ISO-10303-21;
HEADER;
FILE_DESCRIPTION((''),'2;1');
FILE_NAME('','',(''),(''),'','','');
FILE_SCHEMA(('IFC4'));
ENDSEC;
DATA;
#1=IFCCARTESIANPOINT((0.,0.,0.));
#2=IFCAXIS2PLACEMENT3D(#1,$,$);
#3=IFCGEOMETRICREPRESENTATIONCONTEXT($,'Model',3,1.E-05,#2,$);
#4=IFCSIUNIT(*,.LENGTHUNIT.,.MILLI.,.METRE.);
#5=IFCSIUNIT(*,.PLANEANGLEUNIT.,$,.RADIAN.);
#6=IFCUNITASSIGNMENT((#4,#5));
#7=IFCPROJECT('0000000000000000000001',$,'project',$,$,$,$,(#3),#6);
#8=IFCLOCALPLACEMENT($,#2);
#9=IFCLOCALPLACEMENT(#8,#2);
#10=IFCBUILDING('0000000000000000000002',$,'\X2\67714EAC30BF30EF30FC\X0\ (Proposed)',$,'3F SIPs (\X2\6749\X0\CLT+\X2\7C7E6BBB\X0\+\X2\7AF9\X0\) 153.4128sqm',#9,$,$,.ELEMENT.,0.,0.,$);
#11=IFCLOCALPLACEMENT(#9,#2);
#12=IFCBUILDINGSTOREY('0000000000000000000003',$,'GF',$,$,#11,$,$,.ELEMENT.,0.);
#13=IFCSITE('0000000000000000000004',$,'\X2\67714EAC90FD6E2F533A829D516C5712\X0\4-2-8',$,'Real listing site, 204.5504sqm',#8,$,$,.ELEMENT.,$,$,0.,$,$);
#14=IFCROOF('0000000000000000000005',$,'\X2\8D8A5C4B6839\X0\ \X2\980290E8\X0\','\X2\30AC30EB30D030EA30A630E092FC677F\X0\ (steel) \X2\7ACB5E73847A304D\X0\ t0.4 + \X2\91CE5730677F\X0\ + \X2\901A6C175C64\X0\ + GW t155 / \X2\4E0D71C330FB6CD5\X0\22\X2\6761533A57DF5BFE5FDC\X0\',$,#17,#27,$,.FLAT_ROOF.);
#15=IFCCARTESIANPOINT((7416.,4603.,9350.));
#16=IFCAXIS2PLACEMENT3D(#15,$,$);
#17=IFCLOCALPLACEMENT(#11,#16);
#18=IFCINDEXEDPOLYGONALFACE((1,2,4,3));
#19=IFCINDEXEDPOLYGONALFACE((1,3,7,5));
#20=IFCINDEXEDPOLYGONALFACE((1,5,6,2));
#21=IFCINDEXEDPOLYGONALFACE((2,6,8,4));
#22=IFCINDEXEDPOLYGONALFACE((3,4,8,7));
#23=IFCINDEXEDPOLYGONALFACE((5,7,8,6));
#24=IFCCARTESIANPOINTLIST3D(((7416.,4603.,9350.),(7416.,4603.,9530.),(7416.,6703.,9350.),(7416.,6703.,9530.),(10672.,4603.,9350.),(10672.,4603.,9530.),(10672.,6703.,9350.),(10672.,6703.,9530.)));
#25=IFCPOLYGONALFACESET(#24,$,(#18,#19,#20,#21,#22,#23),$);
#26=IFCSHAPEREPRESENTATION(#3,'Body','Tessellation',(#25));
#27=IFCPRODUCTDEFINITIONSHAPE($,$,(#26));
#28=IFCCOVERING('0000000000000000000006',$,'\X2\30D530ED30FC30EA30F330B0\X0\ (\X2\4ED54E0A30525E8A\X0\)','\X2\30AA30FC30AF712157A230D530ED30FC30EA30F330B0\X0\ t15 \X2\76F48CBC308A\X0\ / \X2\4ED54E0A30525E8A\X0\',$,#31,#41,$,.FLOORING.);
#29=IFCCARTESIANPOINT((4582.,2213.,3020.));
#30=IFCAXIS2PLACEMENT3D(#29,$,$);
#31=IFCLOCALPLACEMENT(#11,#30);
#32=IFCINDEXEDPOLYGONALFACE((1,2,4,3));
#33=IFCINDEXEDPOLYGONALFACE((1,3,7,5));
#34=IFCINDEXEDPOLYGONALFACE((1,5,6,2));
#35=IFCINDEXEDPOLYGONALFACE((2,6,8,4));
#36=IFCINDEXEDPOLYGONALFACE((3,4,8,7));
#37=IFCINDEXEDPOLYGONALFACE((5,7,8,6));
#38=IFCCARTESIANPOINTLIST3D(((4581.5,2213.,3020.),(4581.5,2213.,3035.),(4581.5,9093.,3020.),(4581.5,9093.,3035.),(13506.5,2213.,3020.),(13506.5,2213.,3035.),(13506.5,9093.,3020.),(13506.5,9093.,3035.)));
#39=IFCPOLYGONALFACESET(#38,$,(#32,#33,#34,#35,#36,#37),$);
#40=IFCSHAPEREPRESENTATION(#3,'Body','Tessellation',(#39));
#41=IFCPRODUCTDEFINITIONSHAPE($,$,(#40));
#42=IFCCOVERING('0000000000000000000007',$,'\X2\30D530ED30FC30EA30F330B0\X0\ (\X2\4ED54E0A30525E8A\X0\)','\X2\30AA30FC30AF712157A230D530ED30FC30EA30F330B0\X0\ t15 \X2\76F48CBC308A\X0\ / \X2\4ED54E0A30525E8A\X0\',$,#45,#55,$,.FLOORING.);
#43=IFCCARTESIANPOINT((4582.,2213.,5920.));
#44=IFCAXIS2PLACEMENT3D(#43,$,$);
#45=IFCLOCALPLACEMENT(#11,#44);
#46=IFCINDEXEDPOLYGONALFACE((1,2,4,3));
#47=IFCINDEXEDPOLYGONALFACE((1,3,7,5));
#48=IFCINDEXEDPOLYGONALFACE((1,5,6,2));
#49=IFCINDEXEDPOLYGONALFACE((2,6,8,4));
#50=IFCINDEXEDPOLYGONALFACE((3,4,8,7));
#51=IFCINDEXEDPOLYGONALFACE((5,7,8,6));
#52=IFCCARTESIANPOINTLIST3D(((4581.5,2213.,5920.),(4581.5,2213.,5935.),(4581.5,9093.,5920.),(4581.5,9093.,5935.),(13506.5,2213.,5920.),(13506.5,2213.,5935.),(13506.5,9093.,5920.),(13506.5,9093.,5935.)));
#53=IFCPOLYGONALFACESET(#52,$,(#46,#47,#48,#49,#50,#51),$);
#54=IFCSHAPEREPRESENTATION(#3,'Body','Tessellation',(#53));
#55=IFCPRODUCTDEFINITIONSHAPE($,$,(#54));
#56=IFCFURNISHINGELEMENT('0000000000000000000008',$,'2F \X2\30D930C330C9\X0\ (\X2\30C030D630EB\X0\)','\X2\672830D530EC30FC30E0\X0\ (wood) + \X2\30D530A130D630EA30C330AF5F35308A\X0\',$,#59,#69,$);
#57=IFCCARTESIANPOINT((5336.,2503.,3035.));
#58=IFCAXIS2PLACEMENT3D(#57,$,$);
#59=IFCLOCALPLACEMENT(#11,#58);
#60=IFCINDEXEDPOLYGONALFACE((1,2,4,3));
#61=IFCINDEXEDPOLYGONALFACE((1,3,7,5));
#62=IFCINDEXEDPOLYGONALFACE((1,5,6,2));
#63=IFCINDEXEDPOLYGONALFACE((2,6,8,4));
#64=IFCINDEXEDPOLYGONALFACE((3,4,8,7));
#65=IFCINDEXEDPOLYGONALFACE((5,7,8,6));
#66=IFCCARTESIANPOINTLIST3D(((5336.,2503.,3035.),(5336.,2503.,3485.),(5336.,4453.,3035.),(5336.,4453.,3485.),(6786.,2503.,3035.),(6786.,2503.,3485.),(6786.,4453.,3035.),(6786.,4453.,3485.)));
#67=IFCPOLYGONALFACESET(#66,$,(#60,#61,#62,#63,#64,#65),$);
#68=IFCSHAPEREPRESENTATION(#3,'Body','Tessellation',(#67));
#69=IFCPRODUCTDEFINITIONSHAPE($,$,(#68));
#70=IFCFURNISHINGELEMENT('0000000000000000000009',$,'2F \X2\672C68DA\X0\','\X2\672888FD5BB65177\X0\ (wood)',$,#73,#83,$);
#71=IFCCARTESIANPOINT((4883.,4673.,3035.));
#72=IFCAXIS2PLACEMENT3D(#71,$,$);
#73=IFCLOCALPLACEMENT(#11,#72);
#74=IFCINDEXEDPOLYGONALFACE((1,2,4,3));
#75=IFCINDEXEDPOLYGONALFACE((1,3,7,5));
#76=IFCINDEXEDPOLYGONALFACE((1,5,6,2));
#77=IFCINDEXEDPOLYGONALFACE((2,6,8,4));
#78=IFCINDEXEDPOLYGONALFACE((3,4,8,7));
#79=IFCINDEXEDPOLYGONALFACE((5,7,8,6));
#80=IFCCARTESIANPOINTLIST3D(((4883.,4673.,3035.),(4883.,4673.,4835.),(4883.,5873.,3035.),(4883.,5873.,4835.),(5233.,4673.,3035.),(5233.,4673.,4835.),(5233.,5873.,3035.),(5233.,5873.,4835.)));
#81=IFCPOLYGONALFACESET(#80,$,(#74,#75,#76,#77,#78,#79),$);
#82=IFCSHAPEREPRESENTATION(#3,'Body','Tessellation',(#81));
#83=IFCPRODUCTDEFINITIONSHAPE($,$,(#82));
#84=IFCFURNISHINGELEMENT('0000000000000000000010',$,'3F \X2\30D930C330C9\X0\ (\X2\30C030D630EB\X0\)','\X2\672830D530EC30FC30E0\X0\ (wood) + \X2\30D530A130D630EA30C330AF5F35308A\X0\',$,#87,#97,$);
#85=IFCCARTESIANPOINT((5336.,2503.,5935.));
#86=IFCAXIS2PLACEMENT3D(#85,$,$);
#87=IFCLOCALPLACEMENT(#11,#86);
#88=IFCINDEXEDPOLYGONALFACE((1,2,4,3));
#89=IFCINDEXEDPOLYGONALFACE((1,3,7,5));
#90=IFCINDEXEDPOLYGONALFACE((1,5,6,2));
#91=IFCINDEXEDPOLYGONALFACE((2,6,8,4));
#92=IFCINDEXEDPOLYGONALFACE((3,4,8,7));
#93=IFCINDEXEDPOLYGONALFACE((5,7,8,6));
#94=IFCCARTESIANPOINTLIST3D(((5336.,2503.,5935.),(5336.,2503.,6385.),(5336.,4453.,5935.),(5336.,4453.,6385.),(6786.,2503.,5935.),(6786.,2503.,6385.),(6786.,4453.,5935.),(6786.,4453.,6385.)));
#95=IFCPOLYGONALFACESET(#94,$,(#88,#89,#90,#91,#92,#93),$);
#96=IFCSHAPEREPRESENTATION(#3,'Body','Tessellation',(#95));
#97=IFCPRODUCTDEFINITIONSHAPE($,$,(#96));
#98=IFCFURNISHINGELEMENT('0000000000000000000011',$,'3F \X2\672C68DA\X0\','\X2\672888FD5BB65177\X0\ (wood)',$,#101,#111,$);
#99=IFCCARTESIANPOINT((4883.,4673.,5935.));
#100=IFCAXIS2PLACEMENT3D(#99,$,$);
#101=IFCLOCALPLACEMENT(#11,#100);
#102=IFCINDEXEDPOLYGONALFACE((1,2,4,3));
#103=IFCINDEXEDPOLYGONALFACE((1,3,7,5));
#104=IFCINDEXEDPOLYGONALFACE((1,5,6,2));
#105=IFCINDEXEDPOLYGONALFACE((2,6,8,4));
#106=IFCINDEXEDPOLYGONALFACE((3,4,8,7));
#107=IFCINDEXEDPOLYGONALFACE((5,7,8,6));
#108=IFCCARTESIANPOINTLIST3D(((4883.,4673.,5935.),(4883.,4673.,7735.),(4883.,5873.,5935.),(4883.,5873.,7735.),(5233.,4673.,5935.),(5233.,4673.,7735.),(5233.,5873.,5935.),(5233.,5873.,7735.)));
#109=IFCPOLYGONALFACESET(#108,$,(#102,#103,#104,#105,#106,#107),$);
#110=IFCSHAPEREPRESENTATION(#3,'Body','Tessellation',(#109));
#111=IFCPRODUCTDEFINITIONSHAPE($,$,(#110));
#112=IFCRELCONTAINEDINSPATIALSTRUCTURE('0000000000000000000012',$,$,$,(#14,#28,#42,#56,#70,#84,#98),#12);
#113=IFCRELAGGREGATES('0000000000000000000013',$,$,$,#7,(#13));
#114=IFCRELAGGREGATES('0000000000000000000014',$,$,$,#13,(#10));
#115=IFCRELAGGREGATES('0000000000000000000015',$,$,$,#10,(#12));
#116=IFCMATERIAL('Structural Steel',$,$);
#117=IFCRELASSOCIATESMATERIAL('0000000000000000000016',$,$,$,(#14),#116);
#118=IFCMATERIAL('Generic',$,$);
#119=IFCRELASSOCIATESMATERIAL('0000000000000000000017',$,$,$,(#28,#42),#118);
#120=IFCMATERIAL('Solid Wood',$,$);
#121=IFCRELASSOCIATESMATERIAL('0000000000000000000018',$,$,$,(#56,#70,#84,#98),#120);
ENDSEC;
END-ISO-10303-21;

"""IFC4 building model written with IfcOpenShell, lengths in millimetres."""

from ifc_helpers import new_model, si_unit, frame, frame_2d, origin, place, context, project, spatial, rectangle, extrude, material, element, save


model = new_model("IFC4")

# Units and contexts
model_context = context("Model", 3, precision=1e-05, world=origin())
ifc_project = project(units=[si_unit("LENGTHUNIT", "METRE", prefix="MILLI"), si_unit("PLANEANGLEUNIT", "RADIAN")], contexts=[model_context])

# Site, building, storey
site_placement = place(None, origin())
site = spatial("IfcSite", under=ifc_project, at=site_placement, Name="東京都港区芝公園4-2-8", ObjectType="Real listing site, 204.5504sqm", CompositionType="ELEMENT", RefElevation=0.0)
building_placement = place(site_placement, origin())
building = spatial("IfcBuilding", under=site, at=building_placement, Name="東京タワー (Proposed)", ObjectType="3F SIPs (杉CLT+籾殻+竹) 153.4128sqm", CompositionType="ELEMENT", ElevationOfRefHeight=0.0, ElevationOfTerrain=0.0)
storey_placement = place(building_placement, origin())
storey = spatial("IfcBuildingStorey", under=building, at=storey_placement, Name="GF", CompositionType="ELEMENT", Elevation=0.0)

# Shared definitions
ifc_material_1 = material(Name="Solid Wood")

# Roof
ifc_material_2 = material(Name="Structural Steel")
roof_1_placement = place(storey_placement, frame((7416.0, 4603.0, 9350.0)))
element("IfcRoof", 1, at=roof_1_placement, inside=storey, material=ifc_material_2, Name="越屋根 頂部", Description="ガルバリウム鋼板 (steel) 立平葺き t0.4 + 野地板 + 通気層 + GW t155 / 不燃・法22条区域対応", PredefinedType="FLAT_ROOF", context=model_context, shape_type="SweptSolid", body=[
    extrude(rectangle(XDim=3256.0, YDim=2100.0, at=frame_2d((1628.0, 1050.0))), frame((7416.0, 4603.0, 9350.0)), (0.0, 0.0, 1.0), 180.0),
])

# Coverings
ifc_material_3 = material(Name="Generic")
covering_1_placement = place(storey_placement, frame((4582.0, 2213.0, 3020.0)))
element("IfcCovering", 2, at=covering_1_placement, inside=storey, material=ifc_material_3, Name="フローリング (仕上げ床)", Description="オーク無垢フローリング t15 直貼り / 仕上げ床", PredefinedType="FLOORING", context=model_context, shape_type="SweptSolid", body=[
    extrude(rectangle(XDim=8925.0, YDim=6880.0, at=frame_2d((4462.0, 3440.0))), frame((4582.0, 2213.0, 3020.0)), (0.0, 0.0, 1.0), 15.0),
])
covering_2_placement = place(storey_placement, frame((4582.0, 2213.0, 5920.0)))
element("IfcCovering", 3, at=covering_2_placement, inside=storey, material=ifc_material_3, Name="フローリング (仕上げ床)", Description="オーク無垢フローリング t15 直貼り / 仕上げ床", PredefinedType="FLOORING", context=model_context, shape_type="SweptSolid", body=[
    extrude(rectangle(XDim=8925.0, YDim=6880.0, at=frame_2d((4462.0, 3440.0))), frame((4582.0, 2213.0, 5920.0)), (0.0, 0.0, 1.0), 15.0),
])

# Furnishing elements
furnishing_1_placement = place(storey_placement, frame((5336.0, 2503.0, 3035.0)))
element("IfcFurnishingElement", 4, at=furnishing_1_placement, inside=storey, material=ifc_material_1, Name="2F ベッド (ダブル)", Description="木フレーム (wood) + ファブリック張り", context=model_context, shape_type="SweptSolid", body=[
    extrude(rectangle(XDim=1450.0, YDim=1950.0, at=frame_2d((725.0, 975.0))), frame((5336.0, 2503.0, 3035.0)), (0.0, 0.0, 1.0), 450.0),
])
furnishing_2_placement = place(storey_placement, frame((4883.0, 4673.0, 3035.0)))
element("IfcFurnishingElement", 5, at=furnishing_2_placement, inside=storey, material=ifc_material_1, Name="2F 本棚", Description="木製家具 (wood)", context=model_context, shape_type="SweptSolid", body=[
    extrude(rectangle(XDim=350.0, YDim=1200.0, at=frame_2d((175.0, 600.0))), frame((4883.0, 4673.0, 3035.0)), (0.0, 0.0, 1.0), 1800.0),
])
furnishing_3_placement = place(storey_placement, frame((5336.0, 2503.0, 5935.0)))
element("IfcFurnishingElement", 6, at=furnishing_3_placement, inside=storey, material=ifc_material_1, Name="3F ベッド (ダブル)", Description="木フレーム (wood) + ファブリック張り", context=model_context, shape_type="SweptSolid", body=[
    extrude(rectangle(XDim=1450.0, YDim=1950.0, at=frame_2d((725.0, 975.0))), frame((5336.0, 2503.0, 5935.0)), (0.0, 0.0, 1.0), 450.0),
])
furnishing_4_placement = place(storey_placement, frame((4883.0, 4673.0, 5935.0)))
element("IfcFurnishingElement", 7, at=furnishing_4_placement, inside=storey, material=ifc_material_1, Name="3F 本棚", Description="木製家具 (wood)", context=model_context, shape_type="SweptSolid", body=[
    extrude(rectangle(XDim=350.0, YDim=1200.0, at=frame_2d((175.0, 600.0))), frame((4883.0, 4673.0, 5935.0)), (0.0, 0.0, 1.0), 1800.0),
])

save(model, "model.ifc")
